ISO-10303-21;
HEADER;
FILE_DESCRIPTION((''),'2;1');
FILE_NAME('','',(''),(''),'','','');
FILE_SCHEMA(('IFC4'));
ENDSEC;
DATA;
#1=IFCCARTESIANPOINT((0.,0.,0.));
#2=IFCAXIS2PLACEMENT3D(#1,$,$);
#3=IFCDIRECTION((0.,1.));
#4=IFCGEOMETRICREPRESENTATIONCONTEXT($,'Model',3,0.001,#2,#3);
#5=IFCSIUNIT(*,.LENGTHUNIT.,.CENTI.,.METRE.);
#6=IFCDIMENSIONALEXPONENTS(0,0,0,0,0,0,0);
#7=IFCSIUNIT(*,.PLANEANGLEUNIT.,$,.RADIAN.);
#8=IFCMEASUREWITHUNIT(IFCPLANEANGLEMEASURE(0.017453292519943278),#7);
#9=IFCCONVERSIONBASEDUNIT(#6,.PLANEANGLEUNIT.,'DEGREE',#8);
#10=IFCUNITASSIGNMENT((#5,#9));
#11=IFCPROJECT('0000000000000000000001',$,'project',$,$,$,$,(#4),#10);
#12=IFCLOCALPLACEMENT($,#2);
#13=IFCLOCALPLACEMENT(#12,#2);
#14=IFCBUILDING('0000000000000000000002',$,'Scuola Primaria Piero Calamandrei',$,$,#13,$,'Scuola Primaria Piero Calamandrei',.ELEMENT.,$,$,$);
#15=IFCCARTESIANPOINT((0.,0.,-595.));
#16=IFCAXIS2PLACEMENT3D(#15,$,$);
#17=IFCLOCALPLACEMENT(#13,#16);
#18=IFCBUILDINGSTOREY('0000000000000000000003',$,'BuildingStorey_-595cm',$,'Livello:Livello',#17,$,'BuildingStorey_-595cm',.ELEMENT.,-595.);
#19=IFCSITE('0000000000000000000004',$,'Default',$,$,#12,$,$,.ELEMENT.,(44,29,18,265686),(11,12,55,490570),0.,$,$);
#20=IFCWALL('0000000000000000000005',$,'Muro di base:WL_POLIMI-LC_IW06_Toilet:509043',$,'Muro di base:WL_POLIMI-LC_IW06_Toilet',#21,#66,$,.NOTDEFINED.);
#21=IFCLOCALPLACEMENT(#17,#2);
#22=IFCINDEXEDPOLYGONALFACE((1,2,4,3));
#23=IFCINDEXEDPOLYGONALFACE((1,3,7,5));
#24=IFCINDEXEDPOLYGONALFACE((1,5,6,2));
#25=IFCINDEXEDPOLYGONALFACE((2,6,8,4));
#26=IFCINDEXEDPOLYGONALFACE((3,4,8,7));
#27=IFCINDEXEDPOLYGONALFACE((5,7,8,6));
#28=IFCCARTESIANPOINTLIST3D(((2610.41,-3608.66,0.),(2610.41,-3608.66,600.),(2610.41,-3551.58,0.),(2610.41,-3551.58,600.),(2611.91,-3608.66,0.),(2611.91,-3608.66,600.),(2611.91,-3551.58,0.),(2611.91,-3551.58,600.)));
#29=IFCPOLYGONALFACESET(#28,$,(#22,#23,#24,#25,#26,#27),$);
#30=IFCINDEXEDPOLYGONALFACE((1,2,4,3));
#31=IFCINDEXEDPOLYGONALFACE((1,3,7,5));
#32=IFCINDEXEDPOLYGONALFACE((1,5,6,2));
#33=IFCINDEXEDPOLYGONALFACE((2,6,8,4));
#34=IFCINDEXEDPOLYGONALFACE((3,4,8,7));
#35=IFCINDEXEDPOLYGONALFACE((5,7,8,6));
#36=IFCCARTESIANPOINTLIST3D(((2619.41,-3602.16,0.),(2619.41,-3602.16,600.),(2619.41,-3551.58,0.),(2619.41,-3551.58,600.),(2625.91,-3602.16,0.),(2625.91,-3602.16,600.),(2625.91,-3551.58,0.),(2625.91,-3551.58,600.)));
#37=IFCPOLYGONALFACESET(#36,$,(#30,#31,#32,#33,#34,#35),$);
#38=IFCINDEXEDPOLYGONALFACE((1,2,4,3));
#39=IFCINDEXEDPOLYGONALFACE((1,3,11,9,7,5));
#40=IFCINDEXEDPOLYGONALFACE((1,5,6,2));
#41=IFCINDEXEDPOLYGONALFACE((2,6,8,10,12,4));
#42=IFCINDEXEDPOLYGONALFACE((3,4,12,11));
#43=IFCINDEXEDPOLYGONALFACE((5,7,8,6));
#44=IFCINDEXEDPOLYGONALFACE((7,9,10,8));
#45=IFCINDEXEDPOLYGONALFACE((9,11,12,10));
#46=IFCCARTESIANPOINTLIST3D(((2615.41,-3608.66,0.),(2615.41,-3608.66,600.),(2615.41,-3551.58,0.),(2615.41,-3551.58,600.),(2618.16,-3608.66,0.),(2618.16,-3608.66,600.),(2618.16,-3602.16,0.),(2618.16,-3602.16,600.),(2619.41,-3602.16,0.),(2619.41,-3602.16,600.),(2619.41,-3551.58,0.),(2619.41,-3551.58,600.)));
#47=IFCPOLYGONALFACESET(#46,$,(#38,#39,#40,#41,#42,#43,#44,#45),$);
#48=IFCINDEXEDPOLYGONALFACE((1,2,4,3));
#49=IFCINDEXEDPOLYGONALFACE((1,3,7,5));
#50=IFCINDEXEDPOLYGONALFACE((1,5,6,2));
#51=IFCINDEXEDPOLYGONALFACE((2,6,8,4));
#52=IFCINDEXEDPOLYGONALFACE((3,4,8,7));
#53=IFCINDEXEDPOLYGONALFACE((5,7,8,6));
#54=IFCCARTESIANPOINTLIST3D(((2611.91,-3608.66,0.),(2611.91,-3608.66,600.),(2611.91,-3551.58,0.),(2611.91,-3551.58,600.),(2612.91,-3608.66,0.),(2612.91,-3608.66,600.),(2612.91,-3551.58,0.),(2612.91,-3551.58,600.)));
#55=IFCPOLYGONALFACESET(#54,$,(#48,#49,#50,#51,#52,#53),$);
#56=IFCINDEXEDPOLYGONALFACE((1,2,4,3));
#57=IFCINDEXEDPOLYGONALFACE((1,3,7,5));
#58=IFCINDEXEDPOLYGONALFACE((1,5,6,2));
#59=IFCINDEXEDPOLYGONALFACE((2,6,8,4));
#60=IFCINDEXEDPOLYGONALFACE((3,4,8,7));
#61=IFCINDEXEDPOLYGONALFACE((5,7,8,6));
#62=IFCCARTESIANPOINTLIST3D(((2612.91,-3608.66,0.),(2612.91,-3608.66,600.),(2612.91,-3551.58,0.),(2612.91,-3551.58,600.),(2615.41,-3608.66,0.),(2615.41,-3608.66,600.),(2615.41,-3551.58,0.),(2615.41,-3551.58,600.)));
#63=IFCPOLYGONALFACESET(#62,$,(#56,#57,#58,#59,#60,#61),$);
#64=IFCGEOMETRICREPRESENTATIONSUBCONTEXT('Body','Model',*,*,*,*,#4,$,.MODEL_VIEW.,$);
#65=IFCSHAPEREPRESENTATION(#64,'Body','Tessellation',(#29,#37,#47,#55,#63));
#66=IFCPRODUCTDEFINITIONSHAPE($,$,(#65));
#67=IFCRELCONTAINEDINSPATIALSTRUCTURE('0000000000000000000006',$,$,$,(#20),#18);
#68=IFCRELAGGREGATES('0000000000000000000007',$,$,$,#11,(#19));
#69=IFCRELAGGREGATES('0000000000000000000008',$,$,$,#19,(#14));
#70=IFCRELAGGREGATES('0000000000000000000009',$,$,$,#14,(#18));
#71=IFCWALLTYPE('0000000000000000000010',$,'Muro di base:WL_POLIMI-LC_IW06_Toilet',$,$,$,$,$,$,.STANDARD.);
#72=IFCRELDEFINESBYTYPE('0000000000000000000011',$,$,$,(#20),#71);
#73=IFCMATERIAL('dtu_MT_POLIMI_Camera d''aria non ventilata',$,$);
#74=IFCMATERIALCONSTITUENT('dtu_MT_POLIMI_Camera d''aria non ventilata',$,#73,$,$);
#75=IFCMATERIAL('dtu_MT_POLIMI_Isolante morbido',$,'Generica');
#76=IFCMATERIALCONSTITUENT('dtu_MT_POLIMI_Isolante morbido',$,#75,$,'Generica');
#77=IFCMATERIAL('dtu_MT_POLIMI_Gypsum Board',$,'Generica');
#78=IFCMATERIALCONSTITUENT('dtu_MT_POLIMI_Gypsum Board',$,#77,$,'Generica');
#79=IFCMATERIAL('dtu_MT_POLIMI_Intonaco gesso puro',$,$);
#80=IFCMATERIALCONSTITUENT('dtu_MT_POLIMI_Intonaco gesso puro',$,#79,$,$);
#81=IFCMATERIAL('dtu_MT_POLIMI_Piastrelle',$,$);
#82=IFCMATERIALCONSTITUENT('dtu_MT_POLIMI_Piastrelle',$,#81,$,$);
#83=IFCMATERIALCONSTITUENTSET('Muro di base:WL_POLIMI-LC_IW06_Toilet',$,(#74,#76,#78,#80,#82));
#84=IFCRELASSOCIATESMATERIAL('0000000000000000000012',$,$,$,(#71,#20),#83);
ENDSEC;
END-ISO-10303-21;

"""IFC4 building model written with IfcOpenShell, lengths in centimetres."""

from ifc_helpers import new_model, entity, si_unit, converted_unit, direction, frame, origin, place, context, subcontext, project, spatial, indexed_curve, outline, extrude, material, constituent, constituent_set, type_object, element, save


model = new_model("IFC4")

# Units and contexts
model_context = context("Model", 3, precision=0.001, world=origin(), true_north=direction((0.0, 1.0)))
body_context = subcontext(model_context, "Body", "Model", "MODEL_VIEW")
ifc_project = project(units=[si_unit("LENGTHUNIT", "METRE", prefix="CENTI"), converted_unit("PLANEANGLEUNIT", "DEGREE", entity("IfcPlaneAngleMeasure", 0.017453292519943278), si_unit("PLANEANGLEUNIT", "RADIAN"), dimensions=[0, 0, 0, 0, 0, 0, 0])], contexts=[model_context])

# Site, building, storey
site_placement = place(None, origin())
site = spatial("IfcSite", under=ifc_project, at=site_placement, Name="Default", CompositionType="ELEMENT", RefLatitude=(44, 29, 18, 265686), RefLongitude=(11, 12, 55, 490570), RefElevation=0.0)
building_placement = place(site_placement, origin())
building = spatial("IfcBuilding", under=site, at=building_placement, Name="Scuola Primaria Piero Calamandrei", LongName="Scuola Primaria Piero Calamandrei", CompositionType="ELEMENT")
storey_placement = place(building_placement, frame((0.0, 0.0, -595.0)))
storey = spatial("IfcBuildingStorey", under=building, at=storey_placement, Name="BuildingStorey_-595cm", ObjectType="Livello:Livello", LongName="BuildingStorey_-595cm", CompositionType="ELEMENT", Elevation=-595.0)

# Shared definitions
ifc_material_1 = material(Name="dtu_MT_POLIMI_Gypsum Board", Category="Generica")
ifc_material_2 = material(Name="dtu_MT_POLIMI_Isolante morbido", Category="Generica")
ifc_material_3 = material(Name="dtu_MT_POLIMI_Camera d'aria non ventilata")
ifc_material_4 = material(Name="dtu_MT_POLIMI_Intonaco gesso puro")

# Wall
ifc_material_5 = material(Name="dtu_MT_POLIMI_Piastrelle")
ifc_constituent_1 = constituent(ifc_material_3, Name="dtu_MT_POLIMI_Camera d'aria non ventilata")
ifc_constituent_2 = constituent(ifc_material_2, Name="dtu_MT_POLIMI_Isolante morbido", Category="Generica")
ifc_constituent_3 = constituent(ifc_material_1, Name="dtu_MT_POLIMI_Gypsum Board", Category="Generica")
ifc_constituent_4 = constituent(ifc_material_4, Name="dtu_MT_POLIMI_Intonaco gesso puro")
ifc_constituent_5 = constituent(ifc_material_5, Name="dtu_MT_POLIMI_Piastrelle")
ifc_constituent_set_1 = constituent_set(constituents=[ifc_constituent_1, ifc_constituent_2, ifc_constituent_3, ifc_constituent_4, ifc_constituent_5], Name="Muro di base:WL_POLIMI-LC_IW06_Toilet")
wall_type_1 = type_object("IfcWallType", Name="Muro di base:WL_POLIMI-LC_IW06_Toilet", PredefinedType="STANDARD", material=ifc_constituent_set_1)
wall_1_placement = place(storey_placement, frame((2618.16, -3551.58, 0.0), z_axis=(0.0, 0.0, 1.0), x_axis=(0.0, -1.0, 0.0)))
element("IfcWall", 1, at=wall_1_placement, inside=storey, type_object=wall_type_1, material=ifc_constituent_set_1, Name="Muro di base:WL_POLIMI-LC_IW06_Toilet:509043", ObjectType="Muro di base:WL_POLIMI-LC_IW06_Toilet", PredefinedType="NOTDEFINED", context=body_context, shape_type="SweptSolid", body=[
    extrude(outline(indexed_curve([(-0.75, -28.54), (0.75, -28.54), (0.75, 28.54), (-0.75, 28.54), (-0.75, -28.54)], self_intersect=False)), frame((28.54, -7.0, 0.0), z_axis=(0.0, 0.0, 1.0), x_axis=(0.0, 1.0, 0.0)), (0.0, 0.0, 1.0), 600.0),
    extrude(outline(indexed_curve([(-3.25, -25.29), (3.25, -25.29), (3.25, 25.29), (-3.25, 25.29), (-3.25, -25.29)], self_intersect=False)), frame((25.29, 4.5, 0.0), z_axis=(0.0, 0.0, 1.0), x_axis=(0.0, -1.0, 0.0)), (0.0, 0.0, 1.0), 600.0),
    extrude(outline(indexed_curve([(0.5, -14.69), (1.75, -14.69), (1.75, 35.89), (-2.25, 35.89), (-2.25, -21.19), (0.5, -21.19), (0.5, -14.69)], self_intersect=False)), frame((35.89, -0.5, 0.0), z_axis=(0.0, 0.0, 1.0), x_axis=(0.0, 1.0, 0.0)), (0.0, 0.0, 1.0), 600.0),
    extrude(outline(indexed_curve([(-28.54, -0.5), (28.54, -0.5), (28.54, 0.5), (-28.54, 0.5), (-28.54, -0.5)], self_intersect=False)), frame((28.54, -5.75, 0.0)), (0.0, 0.0, 1.0), 600.0),
    extrude(outline(indexed_curve([(-28.54, -1.25), (28.54, -1.25), (28.54, 1.25), (-28.54, 1.25), (-28.54, -1.25)], self_intersect=False)), frame((28.54, -4.0, 0.0)), (0.0, 0.0, 1.0), 600.0),
])

save(model, "model.ifc")
